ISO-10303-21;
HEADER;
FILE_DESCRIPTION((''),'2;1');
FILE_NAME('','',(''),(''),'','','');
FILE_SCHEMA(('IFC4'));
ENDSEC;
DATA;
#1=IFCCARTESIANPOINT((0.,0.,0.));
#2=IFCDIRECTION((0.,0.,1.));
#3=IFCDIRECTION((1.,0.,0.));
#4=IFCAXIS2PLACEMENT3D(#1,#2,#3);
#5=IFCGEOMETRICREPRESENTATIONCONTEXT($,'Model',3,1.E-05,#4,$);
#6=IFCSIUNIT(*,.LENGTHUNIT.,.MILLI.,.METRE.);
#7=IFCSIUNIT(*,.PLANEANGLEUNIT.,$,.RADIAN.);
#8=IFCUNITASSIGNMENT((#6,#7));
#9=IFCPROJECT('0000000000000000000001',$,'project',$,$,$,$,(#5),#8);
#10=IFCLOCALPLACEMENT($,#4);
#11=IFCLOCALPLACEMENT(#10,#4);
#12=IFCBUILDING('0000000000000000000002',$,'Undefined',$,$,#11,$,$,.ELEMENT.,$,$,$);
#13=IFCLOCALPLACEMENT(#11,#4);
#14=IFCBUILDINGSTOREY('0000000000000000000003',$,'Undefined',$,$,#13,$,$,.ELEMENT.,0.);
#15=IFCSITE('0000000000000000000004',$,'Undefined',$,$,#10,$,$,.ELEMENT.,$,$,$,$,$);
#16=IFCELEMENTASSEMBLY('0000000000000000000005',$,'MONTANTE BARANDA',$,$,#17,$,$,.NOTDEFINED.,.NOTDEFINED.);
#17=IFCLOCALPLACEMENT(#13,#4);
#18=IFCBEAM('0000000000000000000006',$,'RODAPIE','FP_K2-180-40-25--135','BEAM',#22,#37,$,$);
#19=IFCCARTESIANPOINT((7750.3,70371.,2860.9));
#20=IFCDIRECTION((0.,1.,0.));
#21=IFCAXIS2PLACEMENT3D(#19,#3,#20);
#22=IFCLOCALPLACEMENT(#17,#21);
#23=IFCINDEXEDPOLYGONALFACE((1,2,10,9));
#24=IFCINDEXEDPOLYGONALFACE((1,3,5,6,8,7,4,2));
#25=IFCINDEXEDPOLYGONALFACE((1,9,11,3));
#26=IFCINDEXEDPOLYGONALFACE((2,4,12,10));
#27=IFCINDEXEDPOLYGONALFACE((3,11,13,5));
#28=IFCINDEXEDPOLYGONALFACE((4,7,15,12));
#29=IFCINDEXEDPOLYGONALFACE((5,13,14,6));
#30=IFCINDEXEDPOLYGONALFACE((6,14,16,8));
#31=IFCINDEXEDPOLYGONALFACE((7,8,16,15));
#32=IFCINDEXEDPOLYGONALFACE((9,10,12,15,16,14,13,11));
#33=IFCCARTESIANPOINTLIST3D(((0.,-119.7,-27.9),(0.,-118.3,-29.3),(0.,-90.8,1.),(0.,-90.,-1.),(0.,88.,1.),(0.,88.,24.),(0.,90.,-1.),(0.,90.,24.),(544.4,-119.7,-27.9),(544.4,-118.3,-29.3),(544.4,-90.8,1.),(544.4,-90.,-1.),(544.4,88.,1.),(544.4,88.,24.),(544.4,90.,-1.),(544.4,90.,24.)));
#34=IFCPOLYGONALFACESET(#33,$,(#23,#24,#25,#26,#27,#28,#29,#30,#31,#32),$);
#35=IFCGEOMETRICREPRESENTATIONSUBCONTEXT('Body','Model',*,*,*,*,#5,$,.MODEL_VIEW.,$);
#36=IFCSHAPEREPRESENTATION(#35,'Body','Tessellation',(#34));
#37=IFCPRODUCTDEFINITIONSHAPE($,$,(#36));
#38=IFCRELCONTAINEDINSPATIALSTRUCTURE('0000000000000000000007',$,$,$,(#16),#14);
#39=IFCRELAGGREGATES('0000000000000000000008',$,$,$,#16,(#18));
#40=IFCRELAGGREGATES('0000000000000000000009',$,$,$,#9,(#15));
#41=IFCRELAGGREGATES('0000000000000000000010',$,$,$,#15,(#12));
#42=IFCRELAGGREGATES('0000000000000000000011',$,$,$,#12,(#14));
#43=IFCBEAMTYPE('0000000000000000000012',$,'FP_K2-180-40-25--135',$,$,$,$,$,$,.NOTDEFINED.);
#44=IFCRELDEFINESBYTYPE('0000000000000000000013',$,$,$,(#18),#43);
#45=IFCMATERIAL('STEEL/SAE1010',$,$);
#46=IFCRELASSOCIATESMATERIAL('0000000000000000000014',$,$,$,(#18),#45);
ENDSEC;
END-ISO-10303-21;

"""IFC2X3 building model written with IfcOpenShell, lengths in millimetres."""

from ifc_helpers import new_model, si_unit, frame, origin_with_axes, place, context, subcontext, project, spatial, polyline, outline, extrude, material, type_object, element, aggregate, save


model = new_model("IFC2X3")

# Units and contexts
model_context = context("Model", 3, precision=1e-05, world=origin_with_axes())
body_context = subcontext(model_context, "Body", "Model", "MODEL_VIEW")
ifc_project = project(units=[si_unit("LENGTHUNIT", "METRE", prefix="MILLI"), si_unit("PLANEANGLEUNIT", "RADIAN")], contexts=[model_context])

# Site, building, storey
site_placement = place(None, origin_with_axes())
site = spatial("IfcSite", under=ifc_project, at=site_placement, Name="Undefined", CompositionType="ELEMENT")
building_placement = place(site_placement, origin_with_axes())
building = spatial("IfcBuilding", under=site, at=building_placement, Name="Undefined", CompositionType="ELEMENT")
storey_placement = place(building_placement, origin_with_axes())
storey = spatial("IfcBuildingStorey", under=building, at=storey_placement, Name="Undefined", CompositionType="ELEMENT", Elevation=0.0)

# Element assembly, beam
assembly_1_placement = place(storey_placement, origin_with_axes())
assembly_1 = element("IfcElementAssembly", 1, at=assembly_1_placement, inside=storey, Name="MONTANTE BARANDA", AssemblyPlace="NOTDEFINED", PredefinedType="NOTDEFINED")
ifc_material_1 = material(Name="STEEL/SAE1010")
beam_type_1 = type_object("IfcBeamType", Name="FP_K2-180-40-25--135", PredefinedType="NOTDEFINED")
beam_1_placement = place(assembly_1_placement, frame((7750.3, 70371.0, 2860.9), z_axis=(1.0, 0.0, 0.0), x_axis=(0.0, 1.0, 0.0)))
beam_1 = element("IfcBeam", 2, at=beam_1_placement, type_object=beam_type_1, material=ifc_material_1, Name="RODAPIE", Description="FP_K2-180-40-25--135", ObjectType="BEAM", context=body_context, shape_type="SweptSolid", body=[
    extrude(outline(polyline([(90.8, 1.0), (119.7, -27.9), (118.3, -29.3), (90.0, -1.0), (-90.0, -1.0), (-90.0, 24.0), (-88.0, 24.0), (-88.0, 1.0), (90.8, 1.0)])), frame((544.4, 0.0, 0.0), z_axis=(-1.0, 0.0, 0.0), x_axis=(0.0, -1.0, 0.0)), (0.0, 0.0, 1.0), 544.4),
])
aggregate(assembly_1, [beam_1])

save(model, "model.ifc")
